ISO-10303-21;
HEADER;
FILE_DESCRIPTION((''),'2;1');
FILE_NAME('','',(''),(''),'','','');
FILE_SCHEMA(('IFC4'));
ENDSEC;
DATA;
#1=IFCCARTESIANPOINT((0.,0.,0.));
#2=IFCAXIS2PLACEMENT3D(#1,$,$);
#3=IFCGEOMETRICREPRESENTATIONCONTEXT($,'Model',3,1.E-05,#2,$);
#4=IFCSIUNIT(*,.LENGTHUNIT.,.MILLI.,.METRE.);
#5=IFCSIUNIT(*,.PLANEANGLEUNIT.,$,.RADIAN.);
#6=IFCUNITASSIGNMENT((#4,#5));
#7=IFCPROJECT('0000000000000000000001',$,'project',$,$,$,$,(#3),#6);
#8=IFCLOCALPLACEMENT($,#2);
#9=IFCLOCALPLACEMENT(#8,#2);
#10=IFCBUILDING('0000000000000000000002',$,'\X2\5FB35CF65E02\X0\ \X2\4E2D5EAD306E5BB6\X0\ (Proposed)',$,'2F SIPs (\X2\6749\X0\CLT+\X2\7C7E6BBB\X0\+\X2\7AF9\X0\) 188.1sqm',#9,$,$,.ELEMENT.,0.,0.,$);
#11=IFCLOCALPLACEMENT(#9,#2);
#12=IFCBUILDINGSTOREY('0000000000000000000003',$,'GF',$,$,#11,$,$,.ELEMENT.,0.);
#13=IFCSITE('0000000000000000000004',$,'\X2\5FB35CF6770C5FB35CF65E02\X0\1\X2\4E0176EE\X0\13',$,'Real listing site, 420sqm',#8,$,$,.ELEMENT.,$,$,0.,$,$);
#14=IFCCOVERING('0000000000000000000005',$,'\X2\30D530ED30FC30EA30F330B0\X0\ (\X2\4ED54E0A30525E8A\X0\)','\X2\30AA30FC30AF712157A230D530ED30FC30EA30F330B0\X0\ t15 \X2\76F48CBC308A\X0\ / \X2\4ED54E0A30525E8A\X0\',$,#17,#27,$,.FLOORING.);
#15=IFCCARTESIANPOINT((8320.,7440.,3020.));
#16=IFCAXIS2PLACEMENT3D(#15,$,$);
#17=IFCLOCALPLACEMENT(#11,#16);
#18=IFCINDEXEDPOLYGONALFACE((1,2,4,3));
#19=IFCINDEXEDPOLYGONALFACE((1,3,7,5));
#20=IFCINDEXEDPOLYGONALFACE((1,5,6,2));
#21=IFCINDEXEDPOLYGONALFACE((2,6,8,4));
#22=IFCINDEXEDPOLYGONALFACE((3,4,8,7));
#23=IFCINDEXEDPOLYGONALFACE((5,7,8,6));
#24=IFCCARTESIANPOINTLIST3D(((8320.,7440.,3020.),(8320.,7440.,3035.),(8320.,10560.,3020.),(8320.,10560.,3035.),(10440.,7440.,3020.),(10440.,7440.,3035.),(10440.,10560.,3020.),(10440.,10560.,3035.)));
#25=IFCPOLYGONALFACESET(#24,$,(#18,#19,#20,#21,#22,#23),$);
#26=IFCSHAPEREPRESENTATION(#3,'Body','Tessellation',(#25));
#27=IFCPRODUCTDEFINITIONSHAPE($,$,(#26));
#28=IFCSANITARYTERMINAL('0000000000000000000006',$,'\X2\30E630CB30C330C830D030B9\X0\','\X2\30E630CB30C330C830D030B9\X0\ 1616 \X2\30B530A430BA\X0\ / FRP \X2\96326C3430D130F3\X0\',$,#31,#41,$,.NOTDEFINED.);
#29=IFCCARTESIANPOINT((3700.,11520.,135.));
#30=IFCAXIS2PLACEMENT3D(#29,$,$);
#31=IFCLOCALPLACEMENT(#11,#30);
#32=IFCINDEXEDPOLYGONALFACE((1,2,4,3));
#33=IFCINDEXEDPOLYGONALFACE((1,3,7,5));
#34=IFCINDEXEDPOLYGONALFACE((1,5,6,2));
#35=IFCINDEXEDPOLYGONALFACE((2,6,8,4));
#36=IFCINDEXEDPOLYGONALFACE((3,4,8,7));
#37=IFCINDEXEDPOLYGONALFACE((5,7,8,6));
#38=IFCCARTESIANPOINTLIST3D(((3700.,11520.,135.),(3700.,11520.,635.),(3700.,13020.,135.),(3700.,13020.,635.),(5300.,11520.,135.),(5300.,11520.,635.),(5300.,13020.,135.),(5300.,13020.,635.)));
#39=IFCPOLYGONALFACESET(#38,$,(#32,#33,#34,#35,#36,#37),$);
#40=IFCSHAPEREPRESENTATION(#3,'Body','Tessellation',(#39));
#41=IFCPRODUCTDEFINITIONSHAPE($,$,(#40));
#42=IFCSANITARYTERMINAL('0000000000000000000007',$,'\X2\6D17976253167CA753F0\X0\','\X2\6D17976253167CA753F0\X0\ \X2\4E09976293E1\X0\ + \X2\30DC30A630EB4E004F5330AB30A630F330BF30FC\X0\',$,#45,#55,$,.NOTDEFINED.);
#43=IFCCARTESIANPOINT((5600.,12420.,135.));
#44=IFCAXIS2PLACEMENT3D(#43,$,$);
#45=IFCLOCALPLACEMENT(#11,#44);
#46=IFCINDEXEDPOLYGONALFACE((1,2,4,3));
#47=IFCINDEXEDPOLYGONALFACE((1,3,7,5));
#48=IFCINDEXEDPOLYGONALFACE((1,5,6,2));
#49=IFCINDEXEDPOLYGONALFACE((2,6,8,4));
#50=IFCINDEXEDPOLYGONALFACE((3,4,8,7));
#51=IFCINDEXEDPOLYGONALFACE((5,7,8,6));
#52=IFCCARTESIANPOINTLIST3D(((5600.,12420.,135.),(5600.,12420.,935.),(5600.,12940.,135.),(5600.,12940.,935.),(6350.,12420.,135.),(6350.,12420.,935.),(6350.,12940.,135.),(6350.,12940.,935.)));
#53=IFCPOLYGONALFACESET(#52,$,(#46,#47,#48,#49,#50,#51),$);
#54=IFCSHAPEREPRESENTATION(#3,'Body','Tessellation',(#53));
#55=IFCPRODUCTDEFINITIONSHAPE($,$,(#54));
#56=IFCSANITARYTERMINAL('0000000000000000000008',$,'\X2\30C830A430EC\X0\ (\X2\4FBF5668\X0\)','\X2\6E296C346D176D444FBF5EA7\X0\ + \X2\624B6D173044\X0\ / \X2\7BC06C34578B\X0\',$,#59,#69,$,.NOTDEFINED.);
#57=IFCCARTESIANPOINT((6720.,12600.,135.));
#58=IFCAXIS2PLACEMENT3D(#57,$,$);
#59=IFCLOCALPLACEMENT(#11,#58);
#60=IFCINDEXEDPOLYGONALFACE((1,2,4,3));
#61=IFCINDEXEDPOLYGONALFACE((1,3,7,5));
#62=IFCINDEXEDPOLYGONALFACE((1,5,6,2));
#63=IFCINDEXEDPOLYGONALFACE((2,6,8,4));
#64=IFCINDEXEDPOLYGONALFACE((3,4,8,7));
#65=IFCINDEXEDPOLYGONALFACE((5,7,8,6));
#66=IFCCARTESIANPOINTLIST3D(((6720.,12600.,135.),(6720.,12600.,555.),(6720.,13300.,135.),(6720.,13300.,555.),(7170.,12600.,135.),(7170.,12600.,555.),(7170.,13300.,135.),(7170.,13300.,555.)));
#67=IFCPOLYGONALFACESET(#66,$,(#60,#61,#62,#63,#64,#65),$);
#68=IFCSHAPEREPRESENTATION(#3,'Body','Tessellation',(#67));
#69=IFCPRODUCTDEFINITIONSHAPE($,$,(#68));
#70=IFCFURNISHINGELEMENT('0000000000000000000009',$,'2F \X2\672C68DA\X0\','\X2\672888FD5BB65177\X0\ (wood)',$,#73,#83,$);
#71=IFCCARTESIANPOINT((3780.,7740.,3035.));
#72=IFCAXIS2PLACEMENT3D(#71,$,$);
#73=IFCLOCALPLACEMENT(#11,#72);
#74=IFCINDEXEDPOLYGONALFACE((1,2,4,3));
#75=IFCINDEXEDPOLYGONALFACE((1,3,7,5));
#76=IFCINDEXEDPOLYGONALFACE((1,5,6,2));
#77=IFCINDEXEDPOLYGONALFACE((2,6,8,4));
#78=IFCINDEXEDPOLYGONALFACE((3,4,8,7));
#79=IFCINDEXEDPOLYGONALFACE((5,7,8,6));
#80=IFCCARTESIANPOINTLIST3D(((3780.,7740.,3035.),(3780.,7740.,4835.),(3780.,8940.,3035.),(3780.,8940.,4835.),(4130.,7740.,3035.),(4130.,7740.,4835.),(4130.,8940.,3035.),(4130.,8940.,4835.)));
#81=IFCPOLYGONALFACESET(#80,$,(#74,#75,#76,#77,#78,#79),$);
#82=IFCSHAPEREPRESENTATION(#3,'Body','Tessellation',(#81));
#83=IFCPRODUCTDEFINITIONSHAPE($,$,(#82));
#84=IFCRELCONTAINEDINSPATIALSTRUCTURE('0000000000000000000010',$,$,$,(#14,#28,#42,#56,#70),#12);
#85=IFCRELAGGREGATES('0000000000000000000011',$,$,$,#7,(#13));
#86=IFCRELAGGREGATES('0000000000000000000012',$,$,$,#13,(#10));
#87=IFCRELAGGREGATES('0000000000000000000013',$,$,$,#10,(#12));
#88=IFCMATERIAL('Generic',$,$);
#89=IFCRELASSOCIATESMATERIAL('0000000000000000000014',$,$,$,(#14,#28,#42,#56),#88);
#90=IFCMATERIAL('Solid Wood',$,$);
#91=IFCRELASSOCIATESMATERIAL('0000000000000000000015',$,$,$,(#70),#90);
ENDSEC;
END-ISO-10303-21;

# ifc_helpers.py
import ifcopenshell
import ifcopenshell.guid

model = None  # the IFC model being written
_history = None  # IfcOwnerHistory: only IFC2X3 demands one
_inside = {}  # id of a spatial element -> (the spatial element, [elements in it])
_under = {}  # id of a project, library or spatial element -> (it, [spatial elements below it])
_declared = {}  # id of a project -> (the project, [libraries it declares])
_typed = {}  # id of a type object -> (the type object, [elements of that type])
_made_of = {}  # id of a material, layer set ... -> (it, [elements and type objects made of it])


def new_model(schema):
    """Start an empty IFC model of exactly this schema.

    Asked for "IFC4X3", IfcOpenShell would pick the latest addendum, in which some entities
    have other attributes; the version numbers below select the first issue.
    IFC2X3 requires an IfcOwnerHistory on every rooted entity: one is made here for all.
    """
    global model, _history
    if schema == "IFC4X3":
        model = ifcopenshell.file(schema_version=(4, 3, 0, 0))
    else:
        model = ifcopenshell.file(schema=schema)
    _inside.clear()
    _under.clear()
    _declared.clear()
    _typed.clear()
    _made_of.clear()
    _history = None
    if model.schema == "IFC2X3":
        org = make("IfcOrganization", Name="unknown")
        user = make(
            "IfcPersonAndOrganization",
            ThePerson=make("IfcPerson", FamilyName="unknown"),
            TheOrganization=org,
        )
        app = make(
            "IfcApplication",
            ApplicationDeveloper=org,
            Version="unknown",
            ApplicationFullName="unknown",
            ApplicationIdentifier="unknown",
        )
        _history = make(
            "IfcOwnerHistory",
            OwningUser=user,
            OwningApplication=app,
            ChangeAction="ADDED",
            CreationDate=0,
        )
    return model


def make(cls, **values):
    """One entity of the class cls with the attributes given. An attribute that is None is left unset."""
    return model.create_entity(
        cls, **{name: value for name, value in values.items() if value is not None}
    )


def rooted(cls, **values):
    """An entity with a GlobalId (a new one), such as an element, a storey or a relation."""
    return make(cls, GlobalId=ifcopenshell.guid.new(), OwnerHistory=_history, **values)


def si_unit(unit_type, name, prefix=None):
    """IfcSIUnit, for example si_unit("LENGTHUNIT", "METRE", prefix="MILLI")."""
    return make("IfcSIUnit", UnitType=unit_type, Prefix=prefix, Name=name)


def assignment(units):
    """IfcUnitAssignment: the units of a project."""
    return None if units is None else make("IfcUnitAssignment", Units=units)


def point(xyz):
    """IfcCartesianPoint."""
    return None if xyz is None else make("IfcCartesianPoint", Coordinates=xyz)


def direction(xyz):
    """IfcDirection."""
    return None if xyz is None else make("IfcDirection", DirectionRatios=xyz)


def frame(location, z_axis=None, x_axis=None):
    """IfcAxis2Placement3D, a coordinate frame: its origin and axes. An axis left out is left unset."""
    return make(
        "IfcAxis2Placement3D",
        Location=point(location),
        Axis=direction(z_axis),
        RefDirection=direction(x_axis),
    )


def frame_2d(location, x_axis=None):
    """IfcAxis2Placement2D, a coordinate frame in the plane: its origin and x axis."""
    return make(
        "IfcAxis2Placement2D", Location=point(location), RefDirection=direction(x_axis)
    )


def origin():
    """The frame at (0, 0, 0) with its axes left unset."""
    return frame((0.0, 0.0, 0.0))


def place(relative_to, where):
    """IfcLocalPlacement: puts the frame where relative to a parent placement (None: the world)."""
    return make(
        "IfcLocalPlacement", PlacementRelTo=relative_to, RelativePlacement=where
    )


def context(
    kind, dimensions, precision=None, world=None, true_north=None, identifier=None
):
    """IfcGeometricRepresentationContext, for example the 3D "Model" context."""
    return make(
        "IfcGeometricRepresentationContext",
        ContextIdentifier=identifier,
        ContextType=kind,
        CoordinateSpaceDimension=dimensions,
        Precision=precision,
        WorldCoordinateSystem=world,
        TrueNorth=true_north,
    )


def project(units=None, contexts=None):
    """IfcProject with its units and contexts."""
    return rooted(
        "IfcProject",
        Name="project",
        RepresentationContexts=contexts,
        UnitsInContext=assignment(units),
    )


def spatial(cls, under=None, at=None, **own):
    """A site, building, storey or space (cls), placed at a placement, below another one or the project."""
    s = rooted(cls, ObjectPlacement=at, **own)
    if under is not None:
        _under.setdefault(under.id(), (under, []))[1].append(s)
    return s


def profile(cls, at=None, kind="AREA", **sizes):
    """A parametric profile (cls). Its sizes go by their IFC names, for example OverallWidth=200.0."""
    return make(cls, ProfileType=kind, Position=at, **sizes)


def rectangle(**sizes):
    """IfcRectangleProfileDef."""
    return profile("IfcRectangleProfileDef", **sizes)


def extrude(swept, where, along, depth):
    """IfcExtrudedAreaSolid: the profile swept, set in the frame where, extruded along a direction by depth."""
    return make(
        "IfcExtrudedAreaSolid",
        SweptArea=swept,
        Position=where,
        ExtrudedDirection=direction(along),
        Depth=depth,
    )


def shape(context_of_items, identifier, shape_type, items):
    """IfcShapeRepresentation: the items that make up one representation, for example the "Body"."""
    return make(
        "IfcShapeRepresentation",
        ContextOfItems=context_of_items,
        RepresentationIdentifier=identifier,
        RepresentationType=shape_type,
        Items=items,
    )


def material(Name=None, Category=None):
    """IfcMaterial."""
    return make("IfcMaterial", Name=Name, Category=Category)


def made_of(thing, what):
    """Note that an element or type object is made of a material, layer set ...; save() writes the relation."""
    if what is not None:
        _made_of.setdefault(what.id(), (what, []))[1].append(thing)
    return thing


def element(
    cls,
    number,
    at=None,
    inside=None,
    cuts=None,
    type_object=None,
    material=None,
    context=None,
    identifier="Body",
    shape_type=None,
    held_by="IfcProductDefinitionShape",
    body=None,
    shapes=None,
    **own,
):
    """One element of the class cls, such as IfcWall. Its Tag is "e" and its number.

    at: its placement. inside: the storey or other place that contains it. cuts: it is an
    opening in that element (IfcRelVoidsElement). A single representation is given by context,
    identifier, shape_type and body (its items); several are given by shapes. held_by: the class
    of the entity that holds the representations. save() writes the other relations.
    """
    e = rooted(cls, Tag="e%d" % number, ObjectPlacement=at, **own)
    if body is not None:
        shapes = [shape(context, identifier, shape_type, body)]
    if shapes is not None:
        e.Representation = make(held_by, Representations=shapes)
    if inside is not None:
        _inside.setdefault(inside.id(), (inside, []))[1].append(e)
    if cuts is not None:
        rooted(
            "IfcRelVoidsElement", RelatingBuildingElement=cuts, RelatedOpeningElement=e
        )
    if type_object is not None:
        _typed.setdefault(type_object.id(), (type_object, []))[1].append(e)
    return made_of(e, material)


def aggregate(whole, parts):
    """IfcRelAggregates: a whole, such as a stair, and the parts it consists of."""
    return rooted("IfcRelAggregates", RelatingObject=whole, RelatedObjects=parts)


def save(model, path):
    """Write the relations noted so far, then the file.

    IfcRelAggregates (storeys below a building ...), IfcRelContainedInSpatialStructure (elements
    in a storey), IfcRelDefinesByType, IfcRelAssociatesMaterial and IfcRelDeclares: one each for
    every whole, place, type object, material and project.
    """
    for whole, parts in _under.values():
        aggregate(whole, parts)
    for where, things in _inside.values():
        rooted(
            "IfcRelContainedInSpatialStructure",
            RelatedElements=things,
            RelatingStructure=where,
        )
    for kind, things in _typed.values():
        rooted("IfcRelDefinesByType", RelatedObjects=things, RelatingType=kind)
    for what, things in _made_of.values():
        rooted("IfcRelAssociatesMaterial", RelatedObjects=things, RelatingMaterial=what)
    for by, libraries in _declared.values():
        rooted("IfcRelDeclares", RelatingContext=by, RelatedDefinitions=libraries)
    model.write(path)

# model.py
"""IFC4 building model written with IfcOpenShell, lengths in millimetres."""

from ifc_helpers import new_model, si_unit, frame, frame_2d, origin, place, context, project, spatial, rectangle, extrude, material, element, save


model = new_model("IFC4")

# Units and contexts
model_context = context("Model", 3, precision=1e-05, world=origin())
ifc_project = project(units=[si_unit("LENGTHUNIT", "METRE", prefix="MILLI"), si_unit("PLANEANGLEUNIT", "RADIAN")], contexts=[model_context])

# Site, building, storey
site_placement = place(None, origin())
site = spatial("IfcSite", under=ifc_project, at=site_placement, Name="徳島県徳島市1丁目13", ObjectType="Real listing site, 420sqm", CompositionType="ELEMENT", RefElevation=0.0)
building_placement = place(site_placement, origin())
building = spatial("IfcBuilding", under=site, at=building_placement, Name="徳島市 中庭の家 (Proposed)", ObjectType="2F SIPs (杉CLT+籾殻+竹) 188.1sqm", CompositionType="ELEMENT", ElevationOfRefHeight=0.0, ElevationOfTerrain=0.0)
storey_placement = place(building_placement, origin())
storey = spatial("IfcBuildingStorey", under=building, at=storey_placement, Name="GF", CompositionType="ELEMENT", Elevation=0.0)

# Shared definitions
ifc_material_1 = material(Name="Solid Wood")
ifc_material_2 = material(Name="Generic")

# Covering
covering_1_placement = place(storey_placement, frame((8320.0, 7440.0, 3020.0)))
element("IfcCovering", 1, at=covering_1_placement, inside=storey, material=ifc_material_2, Name="フローリング (仕上げ床)", Description="オーク無垢フローリング t15 直貼り / 仕上げ床", PredefinedType="FLOORING", context=model_context, shape_type="SweptSolid", body=[
    extrude(rectangle(XDim=2120.0, YDim=3120.0, at=frame_2d((1060.0, 1560.0))), frame((8320.0, 7440.0, 3020.0)), (0.0, 0.0, 1.0), 15.0),
])

# Sanitary terminals
sanitary_terminal_1_placement = place(storey_placement, frame((3700.0, 11520.0, 135.0)))
element("IfcSanitaryTerminal", 2, at=sanitary_terminal_1_placement, inside=storey, material=ifc_material_2, Name="ユニットバス", Description="ユニットバス 1616 サイズ / FRP 防水パン", PredefinedType="NOTDEFINED", context=model_context, shape_type="SweptSolid", body=[
    extrude(rectangle(XDim=1600.0, YDim=1500.0, at=frame_2d((800.0, 750.0))), frame((3700.0, 11520.0, 135.0)), (0.0, 0.0, 1.0), 500.0),
])
sanitary_terminal_2_placement = place(storey_placement, frame((5600.0, 12420.0, 135.0)))
element("IfcSanitaryTerminal", 3, at=sanitary_terminal_2_placement, inside=storey, material=ifc_material_2, Name="洗面化粧台", Description="洗面化粧台 三面鏡 + ボウル一体カウンター", PredefinedType="NOTDEFINED", context=model_context, shape_type="SweptSolid", body=[
    extrude(rectangle(XDim=750.0, YDim=520.0, at=frame_2d((375.0, 260.0))), frame((5600.0, 12420.0, 135.0)), (0.0, 0.0, 1.0), 800.0),
])
sanitary_terminal_3_placement = place(storey_placement, frame((6720.0, 12600.0, 135.0)))
element("IfcSanitaryTerminal", 4, at=sanitary_terminal_3_placement, inside=storey, material=ifc_material_2, Name="トイレ (便器)", Description="温水洗浄便座 + 手洗い / 節水型", PredefinedType="NOTDEFINED", context=model_context, shape_type="SweptSolid", body=[
    extrude(rectangle(XDim=450.0, YDim=700.0, at=frame_2d((225.0, 350.0))), frame((6720.0, 12600.0, 135.0)), (0.0, 0.0, 1.0), 420.0),
])

# Furnishing element
furnishing_placement = place(storey_placement, frame((3780.0, 7740.0, 3035.0)))
element("IfcFurnishingElement", 5, at=furnishing_placement, inside=storey, material=ifc_material_1, Name="2F 本棚", Description="木製家具 (wood)", context=model_context, shape_type="SweptSolid", body=[
    extrude(rectangle(XDim=350.0, YDim=1200.0, at=frame_2d((175.0, 600.0))), frame((3780.0, 7740.0, 3035.0)), (0.0, 0.0, 1.0), 1800.0),
])

save(model, "model.ifc")
